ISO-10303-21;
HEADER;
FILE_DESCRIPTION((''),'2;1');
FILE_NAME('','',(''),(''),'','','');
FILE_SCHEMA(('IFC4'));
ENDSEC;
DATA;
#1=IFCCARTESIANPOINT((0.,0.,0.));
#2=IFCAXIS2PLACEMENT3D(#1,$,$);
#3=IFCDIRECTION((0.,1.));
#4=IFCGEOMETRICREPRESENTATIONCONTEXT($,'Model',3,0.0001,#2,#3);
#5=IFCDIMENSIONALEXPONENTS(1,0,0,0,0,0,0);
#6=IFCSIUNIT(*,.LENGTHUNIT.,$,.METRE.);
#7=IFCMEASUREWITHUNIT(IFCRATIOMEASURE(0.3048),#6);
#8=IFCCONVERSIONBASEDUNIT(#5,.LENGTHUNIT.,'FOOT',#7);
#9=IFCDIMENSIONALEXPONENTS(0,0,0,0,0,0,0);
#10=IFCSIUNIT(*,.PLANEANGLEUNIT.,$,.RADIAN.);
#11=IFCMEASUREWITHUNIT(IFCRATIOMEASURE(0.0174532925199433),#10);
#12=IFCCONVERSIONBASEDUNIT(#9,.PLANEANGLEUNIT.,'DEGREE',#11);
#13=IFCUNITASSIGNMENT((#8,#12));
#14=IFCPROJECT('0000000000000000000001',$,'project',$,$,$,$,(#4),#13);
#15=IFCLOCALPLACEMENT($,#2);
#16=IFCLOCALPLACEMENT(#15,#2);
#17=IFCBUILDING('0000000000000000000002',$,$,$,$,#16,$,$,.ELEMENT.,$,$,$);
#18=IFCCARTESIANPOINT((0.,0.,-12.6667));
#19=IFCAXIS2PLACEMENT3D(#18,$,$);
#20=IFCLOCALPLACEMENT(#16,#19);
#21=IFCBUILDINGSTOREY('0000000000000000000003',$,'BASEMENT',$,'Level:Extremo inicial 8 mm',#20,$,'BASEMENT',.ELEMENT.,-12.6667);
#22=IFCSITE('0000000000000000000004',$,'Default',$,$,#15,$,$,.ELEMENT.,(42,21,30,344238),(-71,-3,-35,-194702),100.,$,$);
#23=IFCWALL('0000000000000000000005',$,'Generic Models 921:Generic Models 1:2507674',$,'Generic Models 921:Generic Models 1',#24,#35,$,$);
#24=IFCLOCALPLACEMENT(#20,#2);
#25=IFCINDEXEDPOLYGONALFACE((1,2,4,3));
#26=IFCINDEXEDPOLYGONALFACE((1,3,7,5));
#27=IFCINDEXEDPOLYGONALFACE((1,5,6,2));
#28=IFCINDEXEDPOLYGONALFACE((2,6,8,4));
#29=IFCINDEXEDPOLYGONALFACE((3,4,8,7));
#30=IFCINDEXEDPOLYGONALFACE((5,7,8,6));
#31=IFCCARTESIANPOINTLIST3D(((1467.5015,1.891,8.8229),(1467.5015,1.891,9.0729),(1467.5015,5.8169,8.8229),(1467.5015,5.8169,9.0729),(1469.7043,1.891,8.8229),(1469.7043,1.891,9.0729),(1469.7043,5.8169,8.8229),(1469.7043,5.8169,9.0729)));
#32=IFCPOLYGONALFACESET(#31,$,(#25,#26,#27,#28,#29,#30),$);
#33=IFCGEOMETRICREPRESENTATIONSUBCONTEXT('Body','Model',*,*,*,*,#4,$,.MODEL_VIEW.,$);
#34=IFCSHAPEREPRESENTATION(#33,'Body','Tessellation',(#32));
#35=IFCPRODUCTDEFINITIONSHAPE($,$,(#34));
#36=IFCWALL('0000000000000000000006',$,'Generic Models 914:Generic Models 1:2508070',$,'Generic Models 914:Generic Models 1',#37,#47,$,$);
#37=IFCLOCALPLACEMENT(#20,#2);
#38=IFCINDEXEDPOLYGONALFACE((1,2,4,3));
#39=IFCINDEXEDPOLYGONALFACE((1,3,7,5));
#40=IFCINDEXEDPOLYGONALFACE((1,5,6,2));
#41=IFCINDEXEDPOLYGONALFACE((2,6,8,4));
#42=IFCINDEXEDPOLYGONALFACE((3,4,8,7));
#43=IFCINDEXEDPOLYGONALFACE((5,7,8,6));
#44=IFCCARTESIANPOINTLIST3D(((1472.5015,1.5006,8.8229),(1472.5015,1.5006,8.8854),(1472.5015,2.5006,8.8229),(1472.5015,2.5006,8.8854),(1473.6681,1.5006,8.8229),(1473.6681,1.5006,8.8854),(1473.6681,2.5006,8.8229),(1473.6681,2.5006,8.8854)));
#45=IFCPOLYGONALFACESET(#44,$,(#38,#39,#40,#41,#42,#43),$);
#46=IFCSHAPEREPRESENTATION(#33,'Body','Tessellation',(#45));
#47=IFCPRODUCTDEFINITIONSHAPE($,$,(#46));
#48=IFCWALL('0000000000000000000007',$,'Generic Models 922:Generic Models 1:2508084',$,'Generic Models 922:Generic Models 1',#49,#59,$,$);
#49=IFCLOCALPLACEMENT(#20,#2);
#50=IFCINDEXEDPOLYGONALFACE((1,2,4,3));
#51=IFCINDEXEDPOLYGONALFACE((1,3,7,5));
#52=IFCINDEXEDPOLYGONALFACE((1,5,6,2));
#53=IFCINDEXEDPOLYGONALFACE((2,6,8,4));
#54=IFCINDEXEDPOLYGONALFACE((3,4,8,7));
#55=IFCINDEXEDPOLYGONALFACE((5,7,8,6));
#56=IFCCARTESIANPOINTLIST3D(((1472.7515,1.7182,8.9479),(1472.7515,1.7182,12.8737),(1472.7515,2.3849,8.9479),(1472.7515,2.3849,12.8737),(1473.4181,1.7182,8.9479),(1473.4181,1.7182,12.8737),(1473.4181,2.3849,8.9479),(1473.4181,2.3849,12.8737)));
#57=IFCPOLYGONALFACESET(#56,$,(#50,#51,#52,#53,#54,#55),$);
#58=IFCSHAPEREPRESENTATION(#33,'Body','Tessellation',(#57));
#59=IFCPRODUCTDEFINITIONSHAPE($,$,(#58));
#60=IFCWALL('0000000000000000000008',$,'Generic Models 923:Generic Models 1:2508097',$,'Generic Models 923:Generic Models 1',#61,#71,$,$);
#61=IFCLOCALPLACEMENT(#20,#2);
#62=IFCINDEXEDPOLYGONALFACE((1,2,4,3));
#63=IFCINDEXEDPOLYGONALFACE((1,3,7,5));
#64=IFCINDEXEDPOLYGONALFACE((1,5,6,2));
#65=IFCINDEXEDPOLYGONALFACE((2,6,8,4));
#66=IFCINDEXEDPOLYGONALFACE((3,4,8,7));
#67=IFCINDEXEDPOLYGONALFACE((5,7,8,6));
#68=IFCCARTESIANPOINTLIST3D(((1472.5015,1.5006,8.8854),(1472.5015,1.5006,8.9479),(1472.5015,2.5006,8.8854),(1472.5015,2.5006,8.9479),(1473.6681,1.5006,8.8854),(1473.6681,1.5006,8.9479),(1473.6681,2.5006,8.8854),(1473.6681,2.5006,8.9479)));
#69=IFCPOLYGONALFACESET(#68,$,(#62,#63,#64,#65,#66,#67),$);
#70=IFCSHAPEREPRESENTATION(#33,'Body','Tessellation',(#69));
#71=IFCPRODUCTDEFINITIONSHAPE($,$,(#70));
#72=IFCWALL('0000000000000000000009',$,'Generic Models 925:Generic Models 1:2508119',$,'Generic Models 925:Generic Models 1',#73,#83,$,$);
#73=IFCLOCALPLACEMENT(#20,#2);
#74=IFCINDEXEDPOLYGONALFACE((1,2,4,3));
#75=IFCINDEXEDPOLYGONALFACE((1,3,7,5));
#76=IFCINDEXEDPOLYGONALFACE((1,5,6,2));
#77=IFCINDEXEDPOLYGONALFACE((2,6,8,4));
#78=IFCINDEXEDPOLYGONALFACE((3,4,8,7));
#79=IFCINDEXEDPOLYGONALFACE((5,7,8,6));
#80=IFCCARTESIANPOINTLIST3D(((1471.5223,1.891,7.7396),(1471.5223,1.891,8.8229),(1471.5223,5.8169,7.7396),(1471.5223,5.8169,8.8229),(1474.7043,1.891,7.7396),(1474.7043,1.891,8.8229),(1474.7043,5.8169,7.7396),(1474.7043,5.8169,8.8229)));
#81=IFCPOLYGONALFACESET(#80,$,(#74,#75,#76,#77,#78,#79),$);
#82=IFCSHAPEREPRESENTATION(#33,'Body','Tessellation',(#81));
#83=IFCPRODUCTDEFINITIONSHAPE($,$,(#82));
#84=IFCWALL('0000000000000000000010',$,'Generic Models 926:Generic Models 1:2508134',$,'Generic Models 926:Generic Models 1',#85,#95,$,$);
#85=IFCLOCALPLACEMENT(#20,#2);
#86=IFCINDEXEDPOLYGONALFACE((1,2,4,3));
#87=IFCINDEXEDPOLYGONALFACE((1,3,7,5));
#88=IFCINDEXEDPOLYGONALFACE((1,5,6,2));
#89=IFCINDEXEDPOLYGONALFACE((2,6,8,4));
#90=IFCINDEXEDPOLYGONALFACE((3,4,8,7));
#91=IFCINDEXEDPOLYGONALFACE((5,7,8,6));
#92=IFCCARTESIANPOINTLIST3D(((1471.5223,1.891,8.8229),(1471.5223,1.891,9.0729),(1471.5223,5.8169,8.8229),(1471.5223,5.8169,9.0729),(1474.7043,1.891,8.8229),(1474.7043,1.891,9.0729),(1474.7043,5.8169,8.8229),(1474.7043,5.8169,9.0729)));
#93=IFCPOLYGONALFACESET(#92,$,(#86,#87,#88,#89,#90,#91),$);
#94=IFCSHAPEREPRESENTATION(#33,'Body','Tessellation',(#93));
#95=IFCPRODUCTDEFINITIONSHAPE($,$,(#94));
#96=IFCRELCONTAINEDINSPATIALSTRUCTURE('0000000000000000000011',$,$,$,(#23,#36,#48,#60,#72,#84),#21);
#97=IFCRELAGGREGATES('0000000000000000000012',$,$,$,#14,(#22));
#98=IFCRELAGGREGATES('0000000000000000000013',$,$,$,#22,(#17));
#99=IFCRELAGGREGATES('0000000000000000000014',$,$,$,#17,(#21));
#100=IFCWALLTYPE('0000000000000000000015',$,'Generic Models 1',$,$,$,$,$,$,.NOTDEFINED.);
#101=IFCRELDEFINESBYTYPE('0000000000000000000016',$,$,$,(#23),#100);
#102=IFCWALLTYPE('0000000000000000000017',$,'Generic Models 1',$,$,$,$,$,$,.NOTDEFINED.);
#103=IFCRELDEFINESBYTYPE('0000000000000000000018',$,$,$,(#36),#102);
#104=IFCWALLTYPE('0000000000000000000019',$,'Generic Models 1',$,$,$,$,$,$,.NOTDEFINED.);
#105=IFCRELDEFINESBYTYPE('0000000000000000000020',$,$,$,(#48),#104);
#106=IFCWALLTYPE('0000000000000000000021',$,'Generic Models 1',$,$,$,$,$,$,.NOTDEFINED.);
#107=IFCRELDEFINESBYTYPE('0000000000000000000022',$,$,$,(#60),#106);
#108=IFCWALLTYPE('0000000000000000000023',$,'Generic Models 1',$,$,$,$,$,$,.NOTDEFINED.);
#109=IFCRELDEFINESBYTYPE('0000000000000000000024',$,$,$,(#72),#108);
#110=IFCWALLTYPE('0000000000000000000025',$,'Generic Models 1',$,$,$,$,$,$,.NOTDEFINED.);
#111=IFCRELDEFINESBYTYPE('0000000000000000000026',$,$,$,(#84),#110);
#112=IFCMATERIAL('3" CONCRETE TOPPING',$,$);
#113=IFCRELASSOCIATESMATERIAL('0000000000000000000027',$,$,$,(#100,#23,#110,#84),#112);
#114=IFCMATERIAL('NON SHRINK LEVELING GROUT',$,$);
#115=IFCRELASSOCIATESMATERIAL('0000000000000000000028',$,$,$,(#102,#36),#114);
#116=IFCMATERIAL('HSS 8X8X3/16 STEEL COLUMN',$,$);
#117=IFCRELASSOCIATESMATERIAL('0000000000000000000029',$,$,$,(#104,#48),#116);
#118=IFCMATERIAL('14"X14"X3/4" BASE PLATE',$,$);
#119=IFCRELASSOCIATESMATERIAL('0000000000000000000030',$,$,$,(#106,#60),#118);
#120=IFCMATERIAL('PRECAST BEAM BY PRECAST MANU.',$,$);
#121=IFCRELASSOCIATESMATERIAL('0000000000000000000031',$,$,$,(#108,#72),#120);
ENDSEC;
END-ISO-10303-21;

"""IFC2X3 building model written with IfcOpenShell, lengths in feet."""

from ifc_helpers import new_model, entity, si_unit, converted_unit, direction, frame, frame_2d, origin, place, context, subcontext, project, spatial, rectangle, extrude, material, type_object, element, save


model = new_model("IFC2X3")

# Units and contexts
model_context = context("Model", 3, precision=0.0001, world=origin(), true_north=direction((0.0, 1.0)))
body_context = subcontext(model_context, "Body", "Model", "MODEL_VIEW")
ifc_project = project(units=[converted_unit("LENGTHUNIT", "FOOT", entity("IfcRatioMeasure", 0.3048), si_unit("LENGTHUNIT", "METRE"), dimensions=[1, 0, 0, 0, 0, 0, 0]), converted_unit("PLANEANGLEUNIT", "DEGREE", entity("IfcRatioMeasure", 0.0174532925199433), si_unit("PLANEANGLEUNIT", "RADIAN"), dimensions=[0, 0, 0, 0, 0, 0, 0])], contexts=[model_context])

# Site, building, storey
site_placement = place(None, origin())
site = spatial("IfcSite", under=ifc_project, at=site_placement, Name="Default", CompositionType="ELEMENT", RefLatitude=(42, 21, 30, 344238), RefLongitude=(-71, -3, -35, -194702), RefElevation=100.0)
building_placement = place(site_placement, origin())
building = spatial("IfcBuilding", under=site, at=building_placement, CompositionType="ELEMENT")
storey_placement = place(building_placement, frame((0.0, 0.0, -12.6667)))
storey = spatial("IfcBuildingStorey", under=building, at=storey_placement, Name="BASEMENT", ObjectType="Level:Extremo inicial 8 mm", LongName="BASEMENT", CompositionType="ELEMENT", Elevation=-12.6667)

# Walls
ifc_material_1 = material(Name="3\" CONCRETE TOPPING")
ifc_material_2 = material(Name="NON SHRINK LEVELING GROUT")
ifc_material_3 = material(Name="HSS 8X8X3/16 STEEL COLUMN")
wall_type_1 = type_object("IfcWallType", Name="Generic Models 1", PredefinedType="NOTDEFINED", material=ifc_material_1)
wall_1_placement = place(storey_placement, frame((1467.5015, 1.891, 8.8229), z_axis=(0.0, 0.0, 1.0), x_axis=(0.0, 1.0, 0.0)))
element("IfcWall", 1, at=wall_1_placement, inside=storey, type_object=wall_type_1, material=ifc_material_1, Name="Generic Models 921:Generic Models 1:2507674", ObjectType="Generic Models 921:Generic Models 1", context=body_context, shape_type="SweptSolid", body=[
    extrude(rectangle(XDim=3.9258, YDim=2.2028, at=frame_2d((0.0, 0.0), x_axis=(1.0, 0.0))), frame((1.9629, -1.1014, 0.0)), (0.0, 0.0, 1.0), 0.25),
])
wall_type_2 = type_object("IfcWallType", Name="Generic Models 1", PredefinedType="NOTDEFINED", material=ifc_material_2)
wall_2_placement = place(storey_placement, frame((1472.5015, 1.5006, 8.8229)))
element("IfcWall", 2, at=wall_2_placement, inside=storey, type_object=wall_type_2, material=ifc_material_2, Name="Generic Models 914:Generic Models 1:2508070", ObjectType="Generic Models 914:Generic Models 1", context=body_context, shape_type="SweptSolid", body=[
    extrude(rectangle(XDim=1.0, YDim=1.1667, at=frame_2d((0.0, 0.0), x_axis=(1.0, 0.0))), frame((0.5833, 0.5, 0.0), z_axis=(0.0, 0.0, 1.0), x_axis=(0.0, 1.0, 0.0)), (0.0, 0.0, 1.0), 0.0625),
])
wall_type_3 = type_object("IfcWallType", Name="Generic Models 1", PredefinedType="NOTDEFINED", material=ifc_material_3)
wall_3_placement = place(storey_placement, frame((1472.7515, 1.7182, 8.9479), z_axis=(0.0, 0.0, 1.0), x_axis=(0.0, 1.0, 0.0)))
element("IfcWall", 3, at=wall_3_placement, inside=storey, type_object=wall_type_3, material=ifc_material_3, Name="Generic Models 922:Generic Models 1:2508084", ObjectType="Generic Models 922:Generic Models 1", context=body_context, shape_type="SweptSolid", body=[
    extrude(rectangle(XDim=0.6667, YDim=0.6667, at=frame_2d((0.0, 0.0), x_axis=(1.0, 0.0))), frame((0.3333, -0.3333, 0.0), z_axis=(0.0, 0.0, 1.0), x_axis=(-1.0, 0.0, 0.0)), (0.0, 0.0, 1.0), 3.9258),
])
ifc_material_4 = material(Name="14\"X14\"X3/4\" BASE PLATE")
wall_type_4 = type_object("IfcWallType", Name="Generic Models 1", PredefinedType="NOTDEFINED", material=ifc_material_4)
wall_4_placement = place(storey_placement, frame((1472.5015, 1.5006, 8.8854)))
element("IfcWall", 4, at=wall_4_placement, inside=storey, type_object=wall_type_4, material=ifc_material_4, Name="Generic Models 923:Generic Models 1:2508097", ObjectType="Generic Models 923:Generic Models 1", context=body_context, shape_type="SweptSolid", body=[
    extrude(rectangle(XDim=1.0, YDim=1.1667, at=frame_2d((0.0, 0.0), x_axis=(1.0, 0.0))), frame((0.5833, 0.5, 0.0), z_axis=(0.0, 0.0, 1.0), x_axis=(0.0, 1.0, 0.0)), (0.0, 0.0, 1.0), 0.0625),
])
ifc_material_5 = material(Name="PRECAST BEAM BY PRECAST MANU.")
wall_type_5 = type_object("IfcWallType", Name="Generic Models 1", PredefinedType="NOTDEFINED", material=ifc_material_5)
wall_5_placement = place(storey_placement, frame((1471.5223, 1.891, 7.7396), z_axis=(0.0, 0.0, 1.0), x_axis=(0.0, 1.0, 0.0)))
element("IfcWall", 5, at=wall_5_placement, inside=storey, type_object=wall_type_5, material=ifc_material_5, Name="Generic Models 925:Generic Models 1:2508119", ObjectType="Generic Models 925:Generic Models 1", context=body_context, shape_type="SweptSolid", body=[
    extrude(rectangle(XDim=3.9258, YDim=3.182, at=frame_2d((0.0, 0.0), x_axis=(1.0, 0.0))), frame((1.9629, -1.591, 0.0)), (0.0, 0.0, 1.0), 1.0833),
])
wall_type_6 = type_object("IfcWallType", Name="Generic Models 1", PredefinedType="NOTDEFINED", material=ifc_material_1)
wall_6_placement = place(storey_placement, frame((1471.5223, 1.891, 8.8229), z_axis=(0.0, 0.0, 1.0), x_axis=(0.0, 1.0, 0.0)))
element("IfcWall", 6, at=wall_6_placement, inside=storey, type_object=wall_type_6, material=ifc_material_1, Name="Generic Models 926:Generic Models 1:2508134", ObjectType="Generic Models 926:Generic Models 1", context=body_context, shape_type="SweptSolid", body=[
    extrude(rectangle(XDim=3.9258, YDim=3.182, at=frame_2d((0.0, 0.0), x_axis=(1.0, 0.0))), frame((1.9629, -1.591, 0.0)), (0.0, 0.0, 1.0), 0.25),
])

save(model, "model.ifc")
